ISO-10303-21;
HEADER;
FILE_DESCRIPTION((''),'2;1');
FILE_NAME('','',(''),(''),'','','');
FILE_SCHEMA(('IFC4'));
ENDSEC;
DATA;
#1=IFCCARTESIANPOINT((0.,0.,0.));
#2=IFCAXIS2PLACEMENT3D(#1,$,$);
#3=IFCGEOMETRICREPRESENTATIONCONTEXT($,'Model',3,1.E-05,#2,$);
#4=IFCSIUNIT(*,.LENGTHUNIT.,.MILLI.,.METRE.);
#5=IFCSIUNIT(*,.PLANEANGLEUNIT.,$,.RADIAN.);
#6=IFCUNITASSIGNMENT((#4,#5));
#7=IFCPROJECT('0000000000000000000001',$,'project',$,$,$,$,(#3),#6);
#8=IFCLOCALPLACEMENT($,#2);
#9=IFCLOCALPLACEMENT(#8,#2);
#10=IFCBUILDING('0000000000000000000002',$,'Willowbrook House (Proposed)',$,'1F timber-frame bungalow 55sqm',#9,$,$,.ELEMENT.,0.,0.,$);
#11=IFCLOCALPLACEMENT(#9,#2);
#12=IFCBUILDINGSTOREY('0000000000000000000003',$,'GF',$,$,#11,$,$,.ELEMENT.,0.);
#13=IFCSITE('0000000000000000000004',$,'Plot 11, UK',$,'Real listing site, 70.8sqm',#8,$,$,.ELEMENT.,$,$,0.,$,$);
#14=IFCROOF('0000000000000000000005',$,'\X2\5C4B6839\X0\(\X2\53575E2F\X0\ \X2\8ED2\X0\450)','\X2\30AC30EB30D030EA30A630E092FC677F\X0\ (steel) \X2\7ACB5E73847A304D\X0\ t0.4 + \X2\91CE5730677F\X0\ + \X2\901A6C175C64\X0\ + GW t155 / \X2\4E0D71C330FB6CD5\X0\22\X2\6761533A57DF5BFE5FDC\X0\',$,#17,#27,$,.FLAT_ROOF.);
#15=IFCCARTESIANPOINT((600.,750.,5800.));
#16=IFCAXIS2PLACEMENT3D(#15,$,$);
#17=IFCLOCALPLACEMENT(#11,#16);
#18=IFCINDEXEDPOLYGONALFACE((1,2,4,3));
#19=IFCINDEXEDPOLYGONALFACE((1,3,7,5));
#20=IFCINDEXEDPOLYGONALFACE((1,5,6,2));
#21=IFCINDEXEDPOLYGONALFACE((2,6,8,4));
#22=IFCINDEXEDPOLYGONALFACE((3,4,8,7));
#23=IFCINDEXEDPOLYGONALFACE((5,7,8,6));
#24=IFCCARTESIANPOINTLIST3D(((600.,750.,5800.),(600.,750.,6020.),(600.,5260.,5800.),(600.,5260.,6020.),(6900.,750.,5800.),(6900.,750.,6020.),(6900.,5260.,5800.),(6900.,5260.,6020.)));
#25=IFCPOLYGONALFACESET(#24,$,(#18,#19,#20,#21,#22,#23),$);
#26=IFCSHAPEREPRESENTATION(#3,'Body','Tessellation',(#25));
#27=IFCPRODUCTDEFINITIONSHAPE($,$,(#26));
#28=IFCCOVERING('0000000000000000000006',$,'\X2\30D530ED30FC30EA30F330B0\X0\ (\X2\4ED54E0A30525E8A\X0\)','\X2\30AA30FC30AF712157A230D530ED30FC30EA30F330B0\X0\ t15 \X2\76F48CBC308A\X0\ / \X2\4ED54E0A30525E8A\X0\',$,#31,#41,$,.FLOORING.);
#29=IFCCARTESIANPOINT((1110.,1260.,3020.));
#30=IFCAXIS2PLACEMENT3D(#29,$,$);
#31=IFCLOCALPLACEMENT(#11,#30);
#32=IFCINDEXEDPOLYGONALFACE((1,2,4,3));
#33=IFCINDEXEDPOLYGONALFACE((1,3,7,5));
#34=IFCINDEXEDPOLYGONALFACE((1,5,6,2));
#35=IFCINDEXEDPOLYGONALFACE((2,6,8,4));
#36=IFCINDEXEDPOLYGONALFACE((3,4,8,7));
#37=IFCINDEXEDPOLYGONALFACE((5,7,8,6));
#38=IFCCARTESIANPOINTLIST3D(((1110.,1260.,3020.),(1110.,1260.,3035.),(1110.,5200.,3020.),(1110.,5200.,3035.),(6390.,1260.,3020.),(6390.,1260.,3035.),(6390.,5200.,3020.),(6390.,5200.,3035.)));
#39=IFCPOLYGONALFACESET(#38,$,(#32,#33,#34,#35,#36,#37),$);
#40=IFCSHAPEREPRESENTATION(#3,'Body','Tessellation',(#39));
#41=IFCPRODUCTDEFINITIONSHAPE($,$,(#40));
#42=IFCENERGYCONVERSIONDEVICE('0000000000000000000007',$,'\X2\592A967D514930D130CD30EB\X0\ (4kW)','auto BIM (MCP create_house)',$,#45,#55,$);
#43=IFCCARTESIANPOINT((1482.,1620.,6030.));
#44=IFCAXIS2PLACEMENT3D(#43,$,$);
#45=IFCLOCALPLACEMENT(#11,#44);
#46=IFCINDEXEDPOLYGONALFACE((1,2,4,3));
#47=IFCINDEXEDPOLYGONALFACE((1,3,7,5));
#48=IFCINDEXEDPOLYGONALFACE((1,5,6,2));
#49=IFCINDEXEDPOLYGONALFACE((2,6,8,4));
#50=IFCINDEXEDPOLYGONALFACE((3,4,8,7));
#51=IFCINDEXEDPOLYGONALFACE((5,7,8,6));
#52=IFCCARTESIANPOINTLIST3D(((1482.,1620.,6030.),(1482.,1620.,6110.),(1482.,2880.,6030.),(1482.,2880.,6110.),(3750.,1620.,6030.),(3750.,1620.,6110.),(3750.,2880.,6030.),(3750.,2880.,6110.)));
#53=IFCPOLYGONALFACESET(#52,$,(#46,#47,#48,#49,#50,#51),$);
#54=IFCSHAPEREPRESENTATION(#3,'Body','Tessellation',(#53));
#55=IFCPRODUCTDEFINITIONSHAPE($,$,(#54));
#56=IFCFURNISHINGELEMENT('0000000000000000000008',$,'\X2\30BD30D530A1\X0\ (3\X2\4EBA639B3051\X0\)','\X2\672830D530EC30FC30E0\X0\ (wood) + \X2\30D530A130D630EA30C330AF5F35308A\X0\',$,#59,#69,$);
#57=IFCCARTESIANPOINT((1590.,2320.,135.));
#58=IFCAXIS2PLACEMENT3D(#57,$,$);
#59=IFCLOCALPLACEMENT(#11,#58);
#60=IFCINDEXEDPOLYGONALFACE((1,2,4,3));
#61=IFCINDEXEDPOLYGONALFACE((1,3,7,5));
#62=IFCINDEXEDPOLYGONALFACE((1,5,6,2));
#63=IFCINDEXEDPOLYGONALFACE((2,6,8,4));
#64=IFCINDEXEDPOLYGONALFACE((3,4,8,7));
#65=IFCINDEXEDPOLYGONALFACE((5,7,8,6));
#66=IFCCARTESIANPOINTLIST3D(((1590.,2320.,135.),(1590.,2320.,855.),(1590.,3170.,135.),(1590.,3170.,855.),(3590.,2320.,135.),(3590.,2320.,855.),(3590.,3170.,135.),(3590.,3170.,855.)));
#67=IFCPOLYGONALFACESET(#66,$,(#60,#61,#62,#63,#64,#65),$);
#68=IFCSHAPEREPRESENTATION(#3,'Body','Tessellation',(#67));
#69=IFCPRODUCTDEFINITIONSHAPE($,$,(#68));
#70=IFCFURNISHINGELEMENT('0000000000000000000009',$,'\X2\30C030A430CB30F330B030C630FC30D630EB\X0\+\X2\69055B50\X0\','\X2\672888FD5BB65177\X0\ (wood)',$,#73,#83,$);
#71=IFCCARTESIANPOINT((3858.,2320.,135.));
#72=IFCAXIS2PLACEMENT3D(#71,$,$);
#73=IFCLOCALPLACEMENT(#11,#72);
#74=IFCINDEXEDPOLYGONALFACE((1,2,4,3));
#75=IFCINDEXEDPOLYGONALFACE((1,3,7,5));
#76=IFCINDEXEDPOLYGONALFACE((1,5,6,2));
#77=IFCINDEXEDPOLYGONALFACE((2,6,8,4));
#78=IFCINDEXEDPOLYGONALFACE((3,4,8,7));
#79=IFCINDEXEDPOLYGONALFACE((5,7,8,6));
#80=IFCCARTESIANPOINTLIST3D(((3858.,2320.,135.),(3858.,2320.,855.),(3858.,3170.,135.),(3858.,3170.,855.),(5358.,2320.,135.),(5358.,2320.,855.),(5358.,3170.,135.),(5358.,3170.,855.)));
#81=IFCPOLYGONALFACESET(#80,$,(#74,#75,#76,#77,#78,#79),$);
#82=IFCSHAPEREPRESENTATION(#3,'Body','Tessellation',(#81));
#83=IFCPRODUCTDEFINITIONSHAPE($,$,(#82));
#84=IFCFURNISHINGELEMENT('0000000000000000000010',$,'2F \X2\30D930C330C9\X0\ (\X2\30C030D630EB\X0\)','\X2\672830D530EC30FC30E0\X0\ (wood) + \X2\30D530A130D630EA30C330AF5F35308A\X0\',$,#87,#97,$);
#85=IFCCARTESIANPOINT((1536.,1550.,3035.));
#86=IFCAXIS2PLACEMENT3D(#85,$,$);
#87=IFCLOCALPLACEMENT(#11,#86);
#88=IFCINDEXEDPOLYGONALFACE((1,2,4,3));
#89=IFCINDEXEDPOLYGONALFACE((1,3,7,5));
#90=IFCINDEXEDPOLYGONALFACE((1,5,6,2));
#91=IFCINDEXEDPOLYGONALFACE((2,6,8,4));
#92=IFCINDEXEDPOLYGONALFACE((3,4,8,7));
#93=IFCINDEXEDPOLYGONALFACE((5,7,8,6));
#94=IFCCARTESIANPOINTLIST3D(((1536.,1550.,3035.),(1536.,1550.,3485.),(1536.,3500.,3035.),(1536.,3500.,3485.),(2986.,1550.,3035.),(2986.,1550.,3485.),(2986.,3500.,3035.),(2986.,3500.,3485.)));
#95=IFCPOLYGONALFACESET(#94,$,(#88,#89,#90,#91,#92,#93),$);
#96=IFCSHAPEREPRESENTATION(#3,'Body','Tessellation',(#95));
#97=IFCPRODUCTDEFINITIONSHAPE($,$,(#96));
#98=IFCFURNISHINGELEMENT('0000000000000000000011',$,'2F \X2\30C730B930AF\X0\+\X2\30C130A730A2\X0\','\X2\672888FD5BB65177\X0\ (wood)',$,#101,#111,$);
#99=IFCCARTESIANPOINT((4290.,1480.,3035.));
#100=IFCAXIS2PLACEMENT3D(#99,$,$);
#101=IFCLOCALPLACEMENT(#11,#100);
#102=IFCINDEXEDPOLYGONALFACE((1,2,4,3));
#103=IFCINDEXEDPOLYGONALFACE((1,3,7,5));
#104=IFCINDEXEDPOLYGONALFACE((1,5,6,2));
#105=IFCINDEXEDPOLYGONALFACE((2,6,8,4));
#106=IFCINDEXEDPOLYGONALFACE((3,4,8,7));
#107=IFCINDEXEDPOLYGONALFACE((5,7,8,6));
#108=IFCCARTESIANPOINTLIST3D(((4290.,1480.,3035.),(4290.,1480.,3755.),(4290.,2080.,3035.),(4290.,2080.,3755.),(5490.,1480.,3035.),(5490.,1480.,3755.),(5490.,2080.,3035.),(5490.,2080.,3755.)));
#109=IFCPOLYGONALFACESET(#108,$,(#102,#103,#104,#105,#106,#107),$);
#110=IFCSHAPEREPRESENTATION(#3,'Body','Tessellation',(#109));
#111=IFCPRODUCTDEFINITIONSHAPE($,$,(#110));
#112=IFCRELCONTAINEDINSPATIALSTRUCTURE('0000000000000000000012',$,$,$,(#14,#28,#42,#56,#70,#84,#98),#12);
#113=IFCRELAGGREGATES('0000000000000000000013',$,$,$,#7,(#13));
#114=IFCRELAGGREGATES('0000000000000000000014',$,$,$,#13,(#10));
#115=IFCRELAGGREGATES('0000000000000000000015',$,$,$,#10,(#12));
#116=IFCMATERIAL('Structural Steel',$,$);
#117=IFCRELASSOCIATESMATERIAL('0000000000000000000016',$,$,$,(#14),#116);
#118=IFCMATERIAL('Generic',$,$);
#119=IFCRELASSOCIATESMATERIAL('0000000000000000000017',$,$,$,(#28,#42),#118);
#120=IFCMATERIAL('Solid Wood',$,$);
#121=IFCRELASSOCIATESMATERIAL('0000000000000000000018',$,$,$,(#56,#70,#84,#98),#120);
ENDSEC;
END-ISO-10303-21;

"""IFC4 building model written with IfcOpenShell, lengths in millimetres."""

from ifc_helpers import new_model, si_unit, frame, frame_2d, origin, place, context, project, spatial, rectangle, extrude, material, element, save


model = new_model("IFC4")

# Units and contexts
model_context = context("Model", 3, precision=1e-05, world=origin())
ifc_project = project(units=[si_unit("LENGTHUNIT", "METRE", prefix="MILLI"), si_unit("PLANEANGLEUNIT", "RADIAN")], contexts=[model_context])

# Site, building, storey
site_placement = place(None, origin())
site = spatial("IfcSite", under=ifc_project, at=site_placement, Name="Plot 11, UK", ObjectType="Real listing site, 70.8sqm", CompositionType="ELEMENT", RefElevation=0.0)
building_placement = place(site_placement, origin())
building = spatial("IfcBuilding", under=site, at=building_placement, Name="Willowbrook House (Proposed)", ObjectType="1F timber-frame bungalow 55sqm", CompositionType="ELEMENT", ElevationOfRefHeight=0.0, ElevationOfTerrain=0.0)
storey_placement = place(building_placement, origin())
storey = spatial("IfcBuildingStorey", under=building, at=storey_placement, Name="GF", CompositionType="ELEMENT", Elevation=0.0)

# Shared definitions
ifc_material_1 = material(Name="Solid Wood")

# Shared definitions
ifc_material_2 = material(Name="Generic")

# Roof
ifc_material_3 = material(Name="Structural Steel")
for number, where, name in (
    (1, (600.0, 750.0, 5800.0), "屋根(南帯 軒450)"),
):
    element("IfcRoof", number, at=place(storey_placement, frame(where)), inside=storey, material=ifc_material_3, Name=name, Description="ガルバリウム鋼板 (steel) 立平葺き t0.4 + 野地板 + 通気層 + GW t155 / 不燃・法22条区域対応", PredefinedType="FLAT_ROOF", context=model_context, shape_type="SweptSolid", body=[
        extrude(rectangle(XDim=6300.0, YDim=4510.0, at=frame_2d((3150.0, 2255.0))), frame((600.0, 750.0, 5800.0)), (0.0, 0.0, 1.0), 220.0),
    ])

# Covering
covering_placement = place(storey_placement, frame((1110.0, 1260.0, 3020.0)))
element("IfcCovering", 2, at=covering_placement, inside=storey, material=ifc_material_2, Name="フローリング (仕上げ床)", Description="オーク無垢フローリング t15 直貼り / 仕上げ床", PredefinedType="FLOORING", context=model_context, shape_type="SweptSolid", body=[
    extrude(rectangle(XDim=5280.0, YDim=3940.0, at=frame_2d((2640.0, 1970.0))), frame((1110.0, 1260.0, 3020.0)), (0.0, 0.0, 1.0), 15.0),
])

# Energy conversion device
energy_conversion_device_placement = place(storey_placement, frame((1482.0, 1620.0, 6030.0)))
element("IfcEnergyConversionDevice", 3, at=energy_conversion_device_placement, inside=storey, material=ifc_material_2, Name="太陽光パネル (4kW)", Description="auto BIM (MCP create_house)", context=model_context, shape_type="SweptSolid", body=[
    extrude(rectangle(XDim=2268.0, YDim=1260.0, at=frame_2d((1134.0, 630.0))), frame((1482.0, 1620.0, 6030.0)), (0.0, 0.0, 1.0), 80.0),
])

# Furnishing elements
furnishing_1_placement = place(storey_placement, frame((1590.0, 2320.0, 135.0)))
element("IfcFurnishingElement", 4, at=furnishing_1_placement, inside=storey, material=ifc_material_1, Name="ソファ (3人掛け)", Description="木フレーム (wood) + ファブリック張り", context=model_context, shape_type="SweptSolid", body=[
    extrude(rectangle(XDim=2000.0, YDim=850.0, at=frame_2d((1000.0, 425.0))), frame((1590.0, 2320.0, 135.0)), (0.0, 0.0, 1.0), 720.0),
])
furnishing_2_placement = place(storey_placement, frame((3858.0, 2320.0, 135.0)))
element("IfcFurnishingElement", 5, at=furnishing_2_placement, inside=storey, material=ifc_material_1, Name="ダイニングテーブル+椅子", Description="木製家具 (wood)", context=model_context, shape_type="SweptSolid", body=[
    extrude(rectangle(XDim=1500.0, YDim=850.0, at=frame_2d((750.0, 425.0))), frame((3858.0, 2320.0, 135.0)), (0.0, 0.0, 1.0), 720.0),
])
furnishing_3_placement = place(storey_placement, frame((1536.0, 1550.0, 3035.0)))
element("IfcFurnishingElement", 6, at=furnishing_3_placement, inside=storey, material=ifc_material_1, Name="2F ベッド (ダブル)", Description="木フレーム (wood) + ファブリック張り", context=model_context, shape_type="SweptSolid", body=[
    extrude(rectangle(XDim=1450.0, YDim=1950.0, at=frame_2d((725.0, 975.0))), frame((1536.0, 1550.0, 3035.0)), (0.0, 0.0, 1.0), 450.0),
])
furnishing_4_placement = place(storey_placement, frame((4290.0, 1480.0, 3035.0)))
element("IfcFurnishingElement", 7, at=furnishing_4_placement, inside=storey, material=ifc_material_1, Name="2F デスク+チェア", Description="木製家具 (wood)", context=model_context, shape_type="SweptSolid", body=[
    extrude(rectangle(XDim=1200.0, YDim=600.0, at=frame_2d((600.0, 300.0))), frame((4290.0, 1480.0, 3035.0)), (0.0, 0.0, 1.0), 720.0),
])

save(model, "model.ifc")
